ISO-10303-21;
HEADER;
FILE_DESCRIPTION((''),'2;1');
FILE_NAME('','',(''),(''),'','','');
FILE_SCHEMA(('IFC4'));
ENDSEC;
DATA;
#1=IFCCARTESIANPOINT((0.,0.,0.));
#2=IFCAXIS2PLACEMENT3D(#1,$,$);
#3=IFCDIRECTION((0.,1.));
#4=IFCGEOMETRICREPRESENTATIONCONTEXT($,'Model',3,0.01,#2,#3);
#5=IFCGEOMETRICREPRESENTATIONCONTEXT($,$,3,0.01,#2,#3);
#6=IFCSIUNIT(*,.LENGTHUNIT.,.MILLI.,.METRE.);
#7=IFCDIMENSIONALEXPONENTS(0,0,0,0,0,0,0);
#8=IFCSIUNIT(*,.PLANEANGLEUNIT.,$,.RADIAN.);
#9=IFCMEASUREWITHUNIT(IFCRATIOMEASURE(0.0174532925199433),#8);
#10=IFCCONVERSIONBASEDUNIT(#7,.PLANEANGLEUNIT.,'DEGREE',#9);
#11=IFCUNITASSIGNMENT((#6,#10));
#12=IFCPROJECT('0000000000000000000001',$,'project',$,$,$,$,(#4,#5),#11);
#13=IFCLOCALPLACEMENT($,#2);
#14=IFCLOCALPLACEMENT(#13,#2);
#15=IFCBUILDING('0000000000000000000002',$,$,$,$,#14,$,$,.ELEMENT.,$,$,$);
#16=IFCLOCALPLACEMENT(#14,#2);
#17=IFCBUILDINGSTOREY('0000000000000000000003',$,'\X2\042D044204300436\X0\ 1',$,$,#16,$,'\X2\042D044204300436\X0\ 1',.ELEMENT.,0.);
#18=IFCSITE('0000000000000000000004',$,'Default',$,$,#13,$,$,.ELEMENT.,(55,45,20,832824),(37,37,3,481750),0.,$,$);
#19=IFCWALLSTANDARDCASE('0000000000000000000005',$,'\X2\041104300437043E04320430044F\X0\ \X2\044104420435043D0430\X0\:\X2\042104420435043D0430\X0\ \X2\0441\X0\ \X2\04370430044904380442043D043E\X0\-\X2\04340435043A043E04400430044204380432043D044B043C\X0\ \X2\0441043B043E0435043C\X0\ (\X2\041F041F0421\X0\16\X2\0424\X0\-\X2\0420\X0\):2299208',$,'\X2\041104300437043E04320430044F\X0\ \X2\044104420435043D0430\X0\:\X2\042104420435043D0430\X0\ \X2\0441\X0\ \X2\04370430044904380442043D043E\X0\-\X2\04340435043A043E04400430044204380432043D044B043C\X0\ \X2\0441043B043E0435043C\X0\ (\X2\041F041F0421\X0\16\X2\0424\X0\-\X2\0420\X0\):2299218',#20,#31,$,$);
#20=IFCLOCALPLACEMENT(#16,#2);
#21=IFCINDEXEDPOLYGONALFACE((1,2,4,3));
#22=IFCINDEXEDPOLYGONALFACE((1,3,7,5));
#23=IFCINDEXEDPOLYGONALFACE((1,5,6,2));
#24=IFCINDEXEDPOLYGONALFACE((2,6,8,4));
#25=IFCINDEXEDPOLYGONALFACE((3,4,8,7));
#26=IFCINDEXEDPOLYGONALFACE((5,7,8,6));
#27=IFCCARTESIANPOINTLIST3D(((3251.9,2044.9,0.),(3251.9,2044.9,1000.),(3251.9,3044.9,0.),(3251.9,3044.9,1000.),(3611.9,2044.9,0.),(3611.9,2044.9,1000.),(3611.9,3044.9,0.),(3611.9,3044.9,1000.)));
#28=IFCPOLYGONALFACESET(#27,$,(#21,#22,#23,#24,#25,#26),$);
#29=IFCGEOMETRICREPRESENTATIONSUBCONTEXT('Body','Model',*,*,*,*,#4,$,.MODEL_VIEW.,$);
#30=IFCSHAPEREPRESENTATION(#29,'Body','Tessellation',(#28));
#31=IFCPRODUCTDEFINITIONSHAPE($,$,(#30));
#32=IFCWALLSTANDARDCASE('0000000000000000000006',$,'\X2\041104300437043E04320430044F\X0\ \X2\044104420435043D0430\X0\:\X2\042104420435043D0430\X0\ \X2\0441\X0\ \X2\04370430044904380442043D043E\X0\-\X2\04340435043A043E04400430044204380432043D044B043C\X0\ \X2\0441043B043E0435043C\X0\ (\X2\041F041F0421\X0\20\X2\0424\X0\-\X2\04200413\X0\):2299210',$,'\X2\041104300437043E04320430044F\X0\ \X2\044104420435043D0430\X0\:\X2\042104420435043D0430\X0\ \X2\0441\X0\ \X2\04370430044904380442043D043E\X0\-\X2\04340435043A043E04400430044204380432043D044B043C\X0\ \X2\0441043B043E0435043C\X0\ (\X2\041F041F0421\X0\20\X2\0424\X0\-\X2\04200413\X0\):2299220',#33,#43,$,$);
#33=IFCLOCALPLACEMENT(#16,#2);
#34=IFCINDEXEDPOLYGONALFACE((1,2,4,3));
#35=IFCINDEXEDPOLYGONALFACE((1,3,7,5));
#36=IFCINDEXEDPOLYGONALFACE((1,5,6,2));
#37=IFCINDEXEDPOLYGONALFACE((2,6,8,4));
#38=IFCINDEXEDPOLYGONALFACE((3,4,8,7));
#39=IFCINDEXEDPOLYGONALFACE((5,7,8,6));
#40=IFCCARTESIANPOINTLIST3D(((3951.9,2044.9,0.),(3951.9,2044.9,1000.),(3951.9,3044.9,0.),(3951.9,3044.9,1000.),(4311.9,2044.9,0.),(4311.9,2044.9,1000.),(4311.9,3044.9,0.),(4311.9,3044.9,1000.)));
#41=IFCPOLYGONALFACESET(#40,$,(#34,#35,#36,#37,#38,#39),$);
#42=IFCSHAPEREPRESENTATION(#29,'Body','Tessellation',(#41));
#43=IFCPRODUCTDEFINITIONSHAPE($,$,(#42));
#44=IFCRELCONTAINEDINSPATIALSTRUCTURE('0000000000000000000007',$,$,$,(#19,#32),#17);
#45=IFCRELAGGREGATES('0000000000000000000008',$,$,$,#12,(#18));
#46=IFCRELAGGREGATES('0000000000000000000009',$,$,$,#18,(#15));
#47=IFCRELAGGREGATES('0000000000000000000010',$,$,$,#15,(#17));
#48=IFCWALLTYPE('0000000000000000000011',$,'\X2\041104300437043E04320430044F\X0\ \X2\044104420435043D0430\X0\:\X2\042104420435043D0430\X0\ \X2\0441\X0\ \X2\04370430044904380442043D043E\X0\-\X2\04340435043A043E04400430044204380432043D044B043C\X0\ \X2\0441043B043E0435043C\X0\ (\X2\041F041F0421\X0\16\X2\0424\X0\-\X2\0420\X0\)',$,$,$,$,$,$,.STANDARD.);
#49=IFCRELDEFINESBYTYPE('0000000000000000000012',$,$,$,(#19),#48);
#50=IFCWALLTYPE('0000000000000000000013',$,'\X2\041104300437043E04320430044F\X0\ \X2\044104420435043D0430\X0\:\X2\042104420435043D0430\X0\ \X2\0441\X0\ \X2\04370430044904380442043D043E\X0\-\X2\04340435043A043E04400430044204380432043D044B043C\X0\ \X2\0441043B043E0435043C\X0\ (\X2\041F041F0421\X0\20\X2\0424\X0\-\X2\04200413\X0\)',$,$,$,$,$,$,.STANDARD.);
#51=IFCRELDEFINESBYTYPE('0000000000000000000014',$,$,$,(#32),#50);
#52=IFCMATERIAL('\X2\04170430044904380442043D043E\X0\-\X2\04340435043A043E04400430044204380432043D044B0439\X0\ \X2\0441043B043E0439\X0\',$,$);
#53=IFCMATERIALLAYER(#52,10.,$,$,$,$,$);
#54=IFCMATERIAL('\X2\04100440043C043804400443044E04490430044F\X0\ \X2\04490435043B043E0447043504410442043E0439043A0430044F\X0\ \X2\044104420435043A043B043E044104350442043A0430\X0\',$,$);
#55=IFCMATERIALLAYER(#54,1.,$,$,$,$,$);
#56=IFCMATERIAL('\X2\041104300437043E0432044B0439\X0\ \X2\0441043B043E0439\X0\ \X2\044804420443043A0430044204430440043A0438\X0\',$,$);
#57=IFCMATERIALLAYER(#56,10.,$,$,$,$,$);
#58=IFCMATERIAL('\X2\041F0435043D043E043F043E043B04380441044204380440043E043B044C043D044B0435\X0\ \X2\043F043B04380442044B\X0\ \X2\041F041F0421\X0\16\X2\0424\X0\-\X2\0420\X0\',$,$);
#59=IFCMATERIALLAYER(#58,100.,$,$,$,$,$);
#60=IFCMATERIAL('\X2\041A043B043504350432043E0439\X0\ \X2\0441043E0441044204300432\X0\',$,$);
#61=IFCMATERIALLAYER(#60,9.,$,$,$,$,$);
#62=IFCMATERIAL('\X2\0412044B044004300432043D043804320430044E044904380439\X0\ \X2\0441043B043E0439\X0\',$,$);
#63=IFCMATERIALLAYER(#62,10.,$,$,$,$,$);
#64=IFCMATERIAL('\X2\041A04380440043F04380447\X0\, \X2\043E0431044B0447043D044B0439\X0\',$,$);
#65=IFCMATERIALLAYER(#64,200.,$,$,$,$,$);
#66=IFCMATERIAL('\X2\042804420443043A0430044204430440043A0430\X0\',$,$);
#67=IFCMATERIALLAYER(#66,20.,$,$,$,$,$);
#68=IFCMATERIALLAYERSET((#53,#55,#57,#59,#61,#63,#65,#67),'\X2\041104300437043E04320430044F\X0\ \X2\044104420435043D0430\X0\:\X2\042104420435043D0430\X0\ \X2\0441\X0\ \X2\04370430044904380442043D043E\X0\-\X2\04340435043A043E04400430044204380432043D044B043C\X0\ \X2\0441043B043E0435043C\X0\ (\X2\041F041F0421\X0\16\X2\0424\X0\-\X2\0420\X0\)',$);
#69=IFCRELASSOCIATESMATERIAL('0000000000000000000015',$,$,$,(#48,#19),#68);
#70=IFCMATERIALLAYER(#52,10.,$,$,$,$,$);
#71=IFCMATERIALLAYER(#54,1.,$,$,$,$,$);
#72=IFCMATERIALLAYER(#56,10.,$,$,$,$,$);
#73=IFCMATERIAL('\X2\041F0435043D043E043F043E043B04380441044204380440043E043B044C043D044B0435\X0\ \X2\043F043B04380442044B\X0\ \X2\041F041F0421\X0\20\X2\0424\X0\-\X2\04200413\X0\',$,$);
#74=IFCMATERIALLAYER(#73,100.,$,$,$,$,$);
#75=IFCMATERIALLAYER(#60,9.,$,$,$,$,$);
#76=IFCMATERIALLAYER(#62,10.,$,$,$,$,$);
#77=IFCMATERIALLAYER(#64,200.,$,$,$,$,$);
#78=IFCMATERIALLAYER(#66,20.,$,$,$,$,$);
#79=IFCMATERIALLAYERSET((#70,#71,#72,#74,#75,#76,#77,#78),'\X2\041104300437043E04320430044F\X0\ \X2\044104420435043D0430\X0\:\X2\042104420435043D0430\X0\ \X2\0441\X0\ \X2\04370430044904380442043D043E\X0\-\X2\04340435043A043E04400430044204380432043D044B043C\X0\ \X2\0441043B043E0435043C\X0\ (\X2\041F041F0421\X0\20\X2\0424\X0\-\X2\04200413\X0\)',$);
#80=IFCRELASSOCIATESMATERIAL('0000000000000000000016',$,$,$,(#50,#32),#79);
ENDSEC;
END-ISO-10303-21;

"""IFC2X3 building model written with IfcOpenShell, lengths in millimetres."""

from ifc_helpers import new_model, entity, si_unit, converted_unit, direction, frame, frame_2d, origin, place, context, subcontext, project, spatial, rectangle, extrude, material, layer, layer_set, layer_usage, type_object, element, save


model = new_model("IFC2X3")

# Units and contexts
model_context = context("Model", 3, precision=0.01, world=origin(), true_north=direction((0.0, 1.0)))
context_of_model = context(None, 3, precision=0.01, world=origin(), true_north=direction((0.0, 1.0)))
body_context = subcontext(model_context, "Body", "Model", "MODEL_VIEW")
ifc_project = project(units=[si_unit("LENGTHUNIT", "METRE", prefix="MILLI"), converted_unit("PLANEANGLEUNIT", "DEGREE", entity("IfcRatioMeasure", 0.0174532925199433), si_unit("PLANEANGLEUNIT", "RADIAN"), dimensions=[0, 0, 0, 0, 0, 0, 0])], contexts=[model_context, context_of_model])

# Site, building, storey
site_placement = place(None, origin())
site = spatial("IfcSite", under=ifc_project, at=site_placement, Name="Default", CompositionType="ELEMENT", RefLatitude=(55, 45, 20, 832824), RefLongitude=(37, 37, 3, 481750), RefElevation=0.0)
building_placement = place(site_placement, origin())
building = spatial("IfcBuilding", under=site, at=building_placement, CompositionType="ELEMENT")
storey_placement = place(building_placement, origin())
storey = spatial("IfcBuildingStorey", under=building, at=storey_placement, Name="Этаж 1", LongName="Этаж 1", CompositionType="ELEMENT", Elevation=0.0)

# Walls
ifc_material_1 = material(Name="Защитно-декоративный слой")
ifc_layer_1 = layer(ifc_material_1, 10.0)
ifc_material_2 = material(Name="Армирующая щелочестойкая стеклосетка")
ifc_layer_2 = layer(ifc_material_2, 1.0)
ifc_material_3 = material(Name="Базовый слой штукатурки")
ifc_layer_3 = layer(ifc_material_3, 10.0)
ifc_material_4 = material(Name="Пенополистирольные плиты ППС16Ф-Р")
ifc_layer_4 = layer(ifc_material_4, 100.0)
ifc_material_5 = material(Name="Клеевой состав")
ifc_layer_5 = layer(ifc_material_5, 9.0)
ifc_material_6 = material(Name="Выравнивающий слой")
ifc_layer_6 = layer(ifc_material_6, 10.0)
ifc_material_7 = material(Name="Кирпич, обычный")
ifc_layer_7 = layer(ifc_material_7, 200.0)
ifc_material_8 = material(Name="Штукатурка")
ifc_layer_8 = layer(ifc_material_8, 20.0)
ifc_layer_set_1 = layer_set([ifc_layer_1, ifc_layer_2, ifc_layer_3, ifc_layer_4, ifc_layer_5, ifc_layer_6, ifc_layer_7, ifc_layer_8], Name="Базовая стена:Стена с защитно-декоративным слоем (ППС16Ф-Р)")
ifc_layer_usage_1 = layer_usage(ifc_layer_set_1, "AXIS2", "POSITIVE", -180.0)
wall_type_1 = type_object("IfcWallType", Name="Базовая стена:Стена с защитно-декоративным слоем (ППС16Ф-Р)", PredefinedType="STANDARD", material=ifc_layer_set_1)
wall_1_placement = place(storey_placement, frame((3431.9, 3044.9, 0.0), z_axis=(0.0, 0.0, 1.0), x_axis=(0.0, -1.0, 0.0)))
element("IfcWallStandardCase", 1, at=wall_1_placement, inside=storey, type_object=wall_type_1, material=ifc_layer_usage_1, Name="Базовая стена:Стена с защитно-декоративным слоем (ППС16Ф-Р):2299208", ObjectType="Базовая стена:Стена с защитно-декоративным слоем (ППС16Ф-Р):2299218", context=body_context, shape_type="SweptSolid", body=[
    extrude(rectangle(XDim=1000.0, YDim=360.0, at=frame_2d((500.0, 0.0), x_axis=(-1.0, 0.0))), origin(), (0.0, 0.0, 1.0), 1000.0),
])
ifc_layer_9 = layer(ifc_material_1, 10.0)
ifc_layer_10 = layer(ifc_material_2, 1.0)
ifc_layer_11 = layer(ifc_material_3, 10.0)
ifc_material_9 = material(Name="Пенополистирольные плиты ППС20Ф-РГ")
ifc_layer_12 = layer(ifc_material_9, 100.0)
ifc_layer_13 = layer(ifc_material_5, 9.0)
ifc_layer_14 = layer(ifc_material_6, 10.0)
ifc_layer_15 = layer(ifc_material_7, 200.0)
ifc_layer_16 = layer(ifc_material_8, 20.0)
ifc_layer_set_2 = layer_set([ifc_layer_9, ifc_layer_10, ifc_layer_11, ifc_layer_12, ifc_layer_13, ifc_layer_14, ifc_layer_15, ifc_layer_16], Name="Базовая стена:Стена с защитно-декоративным слоем (ППС20Ф-РГ)")
ifc_layer_usage_2 = layer_usage(ifc_layer_set_2, "AXIS2", "POSITIVE", -180.0)
wall_type_2 = type_object("IfcWallType", Name="Базовая стена:Стена с защитно-декоративным слоем (ППС20Ф-РГ)", PredefinedType="STANDARD", material=ifc_layer_set_2)
wall_2_placement = place(storey_placement, frame((4131.9, 3044.9, 0.0), z_axis=(0.0, 0.0, 1.0), x_axis=(0.0, -1.0, 0.0)))
element("IfcWallStandardCase", 2, at=wall_2_placement, inside=storey, type_object=wall_type_2, material=ifc_layer_usage_2, Name="Базовая стена:Стена с защитно-декоративным слоем (ППС20Ф-РГ):2299210", ObjectType="Базовая стена:Стена с защитно-декоративным слоем (ППС20Ф-РГ):2299220", context=body_context, shape_type="SweptSolid", body=[
    extrude(rectangle(XDim=1000.0, YDim=360.0, at=frame_2d((500.0, 0.0), x_axis=(-1.0, 0.0))), origin(), (0.0, 0.0, 1.0), 1000.0),
])

save(model, "model.ifc")
